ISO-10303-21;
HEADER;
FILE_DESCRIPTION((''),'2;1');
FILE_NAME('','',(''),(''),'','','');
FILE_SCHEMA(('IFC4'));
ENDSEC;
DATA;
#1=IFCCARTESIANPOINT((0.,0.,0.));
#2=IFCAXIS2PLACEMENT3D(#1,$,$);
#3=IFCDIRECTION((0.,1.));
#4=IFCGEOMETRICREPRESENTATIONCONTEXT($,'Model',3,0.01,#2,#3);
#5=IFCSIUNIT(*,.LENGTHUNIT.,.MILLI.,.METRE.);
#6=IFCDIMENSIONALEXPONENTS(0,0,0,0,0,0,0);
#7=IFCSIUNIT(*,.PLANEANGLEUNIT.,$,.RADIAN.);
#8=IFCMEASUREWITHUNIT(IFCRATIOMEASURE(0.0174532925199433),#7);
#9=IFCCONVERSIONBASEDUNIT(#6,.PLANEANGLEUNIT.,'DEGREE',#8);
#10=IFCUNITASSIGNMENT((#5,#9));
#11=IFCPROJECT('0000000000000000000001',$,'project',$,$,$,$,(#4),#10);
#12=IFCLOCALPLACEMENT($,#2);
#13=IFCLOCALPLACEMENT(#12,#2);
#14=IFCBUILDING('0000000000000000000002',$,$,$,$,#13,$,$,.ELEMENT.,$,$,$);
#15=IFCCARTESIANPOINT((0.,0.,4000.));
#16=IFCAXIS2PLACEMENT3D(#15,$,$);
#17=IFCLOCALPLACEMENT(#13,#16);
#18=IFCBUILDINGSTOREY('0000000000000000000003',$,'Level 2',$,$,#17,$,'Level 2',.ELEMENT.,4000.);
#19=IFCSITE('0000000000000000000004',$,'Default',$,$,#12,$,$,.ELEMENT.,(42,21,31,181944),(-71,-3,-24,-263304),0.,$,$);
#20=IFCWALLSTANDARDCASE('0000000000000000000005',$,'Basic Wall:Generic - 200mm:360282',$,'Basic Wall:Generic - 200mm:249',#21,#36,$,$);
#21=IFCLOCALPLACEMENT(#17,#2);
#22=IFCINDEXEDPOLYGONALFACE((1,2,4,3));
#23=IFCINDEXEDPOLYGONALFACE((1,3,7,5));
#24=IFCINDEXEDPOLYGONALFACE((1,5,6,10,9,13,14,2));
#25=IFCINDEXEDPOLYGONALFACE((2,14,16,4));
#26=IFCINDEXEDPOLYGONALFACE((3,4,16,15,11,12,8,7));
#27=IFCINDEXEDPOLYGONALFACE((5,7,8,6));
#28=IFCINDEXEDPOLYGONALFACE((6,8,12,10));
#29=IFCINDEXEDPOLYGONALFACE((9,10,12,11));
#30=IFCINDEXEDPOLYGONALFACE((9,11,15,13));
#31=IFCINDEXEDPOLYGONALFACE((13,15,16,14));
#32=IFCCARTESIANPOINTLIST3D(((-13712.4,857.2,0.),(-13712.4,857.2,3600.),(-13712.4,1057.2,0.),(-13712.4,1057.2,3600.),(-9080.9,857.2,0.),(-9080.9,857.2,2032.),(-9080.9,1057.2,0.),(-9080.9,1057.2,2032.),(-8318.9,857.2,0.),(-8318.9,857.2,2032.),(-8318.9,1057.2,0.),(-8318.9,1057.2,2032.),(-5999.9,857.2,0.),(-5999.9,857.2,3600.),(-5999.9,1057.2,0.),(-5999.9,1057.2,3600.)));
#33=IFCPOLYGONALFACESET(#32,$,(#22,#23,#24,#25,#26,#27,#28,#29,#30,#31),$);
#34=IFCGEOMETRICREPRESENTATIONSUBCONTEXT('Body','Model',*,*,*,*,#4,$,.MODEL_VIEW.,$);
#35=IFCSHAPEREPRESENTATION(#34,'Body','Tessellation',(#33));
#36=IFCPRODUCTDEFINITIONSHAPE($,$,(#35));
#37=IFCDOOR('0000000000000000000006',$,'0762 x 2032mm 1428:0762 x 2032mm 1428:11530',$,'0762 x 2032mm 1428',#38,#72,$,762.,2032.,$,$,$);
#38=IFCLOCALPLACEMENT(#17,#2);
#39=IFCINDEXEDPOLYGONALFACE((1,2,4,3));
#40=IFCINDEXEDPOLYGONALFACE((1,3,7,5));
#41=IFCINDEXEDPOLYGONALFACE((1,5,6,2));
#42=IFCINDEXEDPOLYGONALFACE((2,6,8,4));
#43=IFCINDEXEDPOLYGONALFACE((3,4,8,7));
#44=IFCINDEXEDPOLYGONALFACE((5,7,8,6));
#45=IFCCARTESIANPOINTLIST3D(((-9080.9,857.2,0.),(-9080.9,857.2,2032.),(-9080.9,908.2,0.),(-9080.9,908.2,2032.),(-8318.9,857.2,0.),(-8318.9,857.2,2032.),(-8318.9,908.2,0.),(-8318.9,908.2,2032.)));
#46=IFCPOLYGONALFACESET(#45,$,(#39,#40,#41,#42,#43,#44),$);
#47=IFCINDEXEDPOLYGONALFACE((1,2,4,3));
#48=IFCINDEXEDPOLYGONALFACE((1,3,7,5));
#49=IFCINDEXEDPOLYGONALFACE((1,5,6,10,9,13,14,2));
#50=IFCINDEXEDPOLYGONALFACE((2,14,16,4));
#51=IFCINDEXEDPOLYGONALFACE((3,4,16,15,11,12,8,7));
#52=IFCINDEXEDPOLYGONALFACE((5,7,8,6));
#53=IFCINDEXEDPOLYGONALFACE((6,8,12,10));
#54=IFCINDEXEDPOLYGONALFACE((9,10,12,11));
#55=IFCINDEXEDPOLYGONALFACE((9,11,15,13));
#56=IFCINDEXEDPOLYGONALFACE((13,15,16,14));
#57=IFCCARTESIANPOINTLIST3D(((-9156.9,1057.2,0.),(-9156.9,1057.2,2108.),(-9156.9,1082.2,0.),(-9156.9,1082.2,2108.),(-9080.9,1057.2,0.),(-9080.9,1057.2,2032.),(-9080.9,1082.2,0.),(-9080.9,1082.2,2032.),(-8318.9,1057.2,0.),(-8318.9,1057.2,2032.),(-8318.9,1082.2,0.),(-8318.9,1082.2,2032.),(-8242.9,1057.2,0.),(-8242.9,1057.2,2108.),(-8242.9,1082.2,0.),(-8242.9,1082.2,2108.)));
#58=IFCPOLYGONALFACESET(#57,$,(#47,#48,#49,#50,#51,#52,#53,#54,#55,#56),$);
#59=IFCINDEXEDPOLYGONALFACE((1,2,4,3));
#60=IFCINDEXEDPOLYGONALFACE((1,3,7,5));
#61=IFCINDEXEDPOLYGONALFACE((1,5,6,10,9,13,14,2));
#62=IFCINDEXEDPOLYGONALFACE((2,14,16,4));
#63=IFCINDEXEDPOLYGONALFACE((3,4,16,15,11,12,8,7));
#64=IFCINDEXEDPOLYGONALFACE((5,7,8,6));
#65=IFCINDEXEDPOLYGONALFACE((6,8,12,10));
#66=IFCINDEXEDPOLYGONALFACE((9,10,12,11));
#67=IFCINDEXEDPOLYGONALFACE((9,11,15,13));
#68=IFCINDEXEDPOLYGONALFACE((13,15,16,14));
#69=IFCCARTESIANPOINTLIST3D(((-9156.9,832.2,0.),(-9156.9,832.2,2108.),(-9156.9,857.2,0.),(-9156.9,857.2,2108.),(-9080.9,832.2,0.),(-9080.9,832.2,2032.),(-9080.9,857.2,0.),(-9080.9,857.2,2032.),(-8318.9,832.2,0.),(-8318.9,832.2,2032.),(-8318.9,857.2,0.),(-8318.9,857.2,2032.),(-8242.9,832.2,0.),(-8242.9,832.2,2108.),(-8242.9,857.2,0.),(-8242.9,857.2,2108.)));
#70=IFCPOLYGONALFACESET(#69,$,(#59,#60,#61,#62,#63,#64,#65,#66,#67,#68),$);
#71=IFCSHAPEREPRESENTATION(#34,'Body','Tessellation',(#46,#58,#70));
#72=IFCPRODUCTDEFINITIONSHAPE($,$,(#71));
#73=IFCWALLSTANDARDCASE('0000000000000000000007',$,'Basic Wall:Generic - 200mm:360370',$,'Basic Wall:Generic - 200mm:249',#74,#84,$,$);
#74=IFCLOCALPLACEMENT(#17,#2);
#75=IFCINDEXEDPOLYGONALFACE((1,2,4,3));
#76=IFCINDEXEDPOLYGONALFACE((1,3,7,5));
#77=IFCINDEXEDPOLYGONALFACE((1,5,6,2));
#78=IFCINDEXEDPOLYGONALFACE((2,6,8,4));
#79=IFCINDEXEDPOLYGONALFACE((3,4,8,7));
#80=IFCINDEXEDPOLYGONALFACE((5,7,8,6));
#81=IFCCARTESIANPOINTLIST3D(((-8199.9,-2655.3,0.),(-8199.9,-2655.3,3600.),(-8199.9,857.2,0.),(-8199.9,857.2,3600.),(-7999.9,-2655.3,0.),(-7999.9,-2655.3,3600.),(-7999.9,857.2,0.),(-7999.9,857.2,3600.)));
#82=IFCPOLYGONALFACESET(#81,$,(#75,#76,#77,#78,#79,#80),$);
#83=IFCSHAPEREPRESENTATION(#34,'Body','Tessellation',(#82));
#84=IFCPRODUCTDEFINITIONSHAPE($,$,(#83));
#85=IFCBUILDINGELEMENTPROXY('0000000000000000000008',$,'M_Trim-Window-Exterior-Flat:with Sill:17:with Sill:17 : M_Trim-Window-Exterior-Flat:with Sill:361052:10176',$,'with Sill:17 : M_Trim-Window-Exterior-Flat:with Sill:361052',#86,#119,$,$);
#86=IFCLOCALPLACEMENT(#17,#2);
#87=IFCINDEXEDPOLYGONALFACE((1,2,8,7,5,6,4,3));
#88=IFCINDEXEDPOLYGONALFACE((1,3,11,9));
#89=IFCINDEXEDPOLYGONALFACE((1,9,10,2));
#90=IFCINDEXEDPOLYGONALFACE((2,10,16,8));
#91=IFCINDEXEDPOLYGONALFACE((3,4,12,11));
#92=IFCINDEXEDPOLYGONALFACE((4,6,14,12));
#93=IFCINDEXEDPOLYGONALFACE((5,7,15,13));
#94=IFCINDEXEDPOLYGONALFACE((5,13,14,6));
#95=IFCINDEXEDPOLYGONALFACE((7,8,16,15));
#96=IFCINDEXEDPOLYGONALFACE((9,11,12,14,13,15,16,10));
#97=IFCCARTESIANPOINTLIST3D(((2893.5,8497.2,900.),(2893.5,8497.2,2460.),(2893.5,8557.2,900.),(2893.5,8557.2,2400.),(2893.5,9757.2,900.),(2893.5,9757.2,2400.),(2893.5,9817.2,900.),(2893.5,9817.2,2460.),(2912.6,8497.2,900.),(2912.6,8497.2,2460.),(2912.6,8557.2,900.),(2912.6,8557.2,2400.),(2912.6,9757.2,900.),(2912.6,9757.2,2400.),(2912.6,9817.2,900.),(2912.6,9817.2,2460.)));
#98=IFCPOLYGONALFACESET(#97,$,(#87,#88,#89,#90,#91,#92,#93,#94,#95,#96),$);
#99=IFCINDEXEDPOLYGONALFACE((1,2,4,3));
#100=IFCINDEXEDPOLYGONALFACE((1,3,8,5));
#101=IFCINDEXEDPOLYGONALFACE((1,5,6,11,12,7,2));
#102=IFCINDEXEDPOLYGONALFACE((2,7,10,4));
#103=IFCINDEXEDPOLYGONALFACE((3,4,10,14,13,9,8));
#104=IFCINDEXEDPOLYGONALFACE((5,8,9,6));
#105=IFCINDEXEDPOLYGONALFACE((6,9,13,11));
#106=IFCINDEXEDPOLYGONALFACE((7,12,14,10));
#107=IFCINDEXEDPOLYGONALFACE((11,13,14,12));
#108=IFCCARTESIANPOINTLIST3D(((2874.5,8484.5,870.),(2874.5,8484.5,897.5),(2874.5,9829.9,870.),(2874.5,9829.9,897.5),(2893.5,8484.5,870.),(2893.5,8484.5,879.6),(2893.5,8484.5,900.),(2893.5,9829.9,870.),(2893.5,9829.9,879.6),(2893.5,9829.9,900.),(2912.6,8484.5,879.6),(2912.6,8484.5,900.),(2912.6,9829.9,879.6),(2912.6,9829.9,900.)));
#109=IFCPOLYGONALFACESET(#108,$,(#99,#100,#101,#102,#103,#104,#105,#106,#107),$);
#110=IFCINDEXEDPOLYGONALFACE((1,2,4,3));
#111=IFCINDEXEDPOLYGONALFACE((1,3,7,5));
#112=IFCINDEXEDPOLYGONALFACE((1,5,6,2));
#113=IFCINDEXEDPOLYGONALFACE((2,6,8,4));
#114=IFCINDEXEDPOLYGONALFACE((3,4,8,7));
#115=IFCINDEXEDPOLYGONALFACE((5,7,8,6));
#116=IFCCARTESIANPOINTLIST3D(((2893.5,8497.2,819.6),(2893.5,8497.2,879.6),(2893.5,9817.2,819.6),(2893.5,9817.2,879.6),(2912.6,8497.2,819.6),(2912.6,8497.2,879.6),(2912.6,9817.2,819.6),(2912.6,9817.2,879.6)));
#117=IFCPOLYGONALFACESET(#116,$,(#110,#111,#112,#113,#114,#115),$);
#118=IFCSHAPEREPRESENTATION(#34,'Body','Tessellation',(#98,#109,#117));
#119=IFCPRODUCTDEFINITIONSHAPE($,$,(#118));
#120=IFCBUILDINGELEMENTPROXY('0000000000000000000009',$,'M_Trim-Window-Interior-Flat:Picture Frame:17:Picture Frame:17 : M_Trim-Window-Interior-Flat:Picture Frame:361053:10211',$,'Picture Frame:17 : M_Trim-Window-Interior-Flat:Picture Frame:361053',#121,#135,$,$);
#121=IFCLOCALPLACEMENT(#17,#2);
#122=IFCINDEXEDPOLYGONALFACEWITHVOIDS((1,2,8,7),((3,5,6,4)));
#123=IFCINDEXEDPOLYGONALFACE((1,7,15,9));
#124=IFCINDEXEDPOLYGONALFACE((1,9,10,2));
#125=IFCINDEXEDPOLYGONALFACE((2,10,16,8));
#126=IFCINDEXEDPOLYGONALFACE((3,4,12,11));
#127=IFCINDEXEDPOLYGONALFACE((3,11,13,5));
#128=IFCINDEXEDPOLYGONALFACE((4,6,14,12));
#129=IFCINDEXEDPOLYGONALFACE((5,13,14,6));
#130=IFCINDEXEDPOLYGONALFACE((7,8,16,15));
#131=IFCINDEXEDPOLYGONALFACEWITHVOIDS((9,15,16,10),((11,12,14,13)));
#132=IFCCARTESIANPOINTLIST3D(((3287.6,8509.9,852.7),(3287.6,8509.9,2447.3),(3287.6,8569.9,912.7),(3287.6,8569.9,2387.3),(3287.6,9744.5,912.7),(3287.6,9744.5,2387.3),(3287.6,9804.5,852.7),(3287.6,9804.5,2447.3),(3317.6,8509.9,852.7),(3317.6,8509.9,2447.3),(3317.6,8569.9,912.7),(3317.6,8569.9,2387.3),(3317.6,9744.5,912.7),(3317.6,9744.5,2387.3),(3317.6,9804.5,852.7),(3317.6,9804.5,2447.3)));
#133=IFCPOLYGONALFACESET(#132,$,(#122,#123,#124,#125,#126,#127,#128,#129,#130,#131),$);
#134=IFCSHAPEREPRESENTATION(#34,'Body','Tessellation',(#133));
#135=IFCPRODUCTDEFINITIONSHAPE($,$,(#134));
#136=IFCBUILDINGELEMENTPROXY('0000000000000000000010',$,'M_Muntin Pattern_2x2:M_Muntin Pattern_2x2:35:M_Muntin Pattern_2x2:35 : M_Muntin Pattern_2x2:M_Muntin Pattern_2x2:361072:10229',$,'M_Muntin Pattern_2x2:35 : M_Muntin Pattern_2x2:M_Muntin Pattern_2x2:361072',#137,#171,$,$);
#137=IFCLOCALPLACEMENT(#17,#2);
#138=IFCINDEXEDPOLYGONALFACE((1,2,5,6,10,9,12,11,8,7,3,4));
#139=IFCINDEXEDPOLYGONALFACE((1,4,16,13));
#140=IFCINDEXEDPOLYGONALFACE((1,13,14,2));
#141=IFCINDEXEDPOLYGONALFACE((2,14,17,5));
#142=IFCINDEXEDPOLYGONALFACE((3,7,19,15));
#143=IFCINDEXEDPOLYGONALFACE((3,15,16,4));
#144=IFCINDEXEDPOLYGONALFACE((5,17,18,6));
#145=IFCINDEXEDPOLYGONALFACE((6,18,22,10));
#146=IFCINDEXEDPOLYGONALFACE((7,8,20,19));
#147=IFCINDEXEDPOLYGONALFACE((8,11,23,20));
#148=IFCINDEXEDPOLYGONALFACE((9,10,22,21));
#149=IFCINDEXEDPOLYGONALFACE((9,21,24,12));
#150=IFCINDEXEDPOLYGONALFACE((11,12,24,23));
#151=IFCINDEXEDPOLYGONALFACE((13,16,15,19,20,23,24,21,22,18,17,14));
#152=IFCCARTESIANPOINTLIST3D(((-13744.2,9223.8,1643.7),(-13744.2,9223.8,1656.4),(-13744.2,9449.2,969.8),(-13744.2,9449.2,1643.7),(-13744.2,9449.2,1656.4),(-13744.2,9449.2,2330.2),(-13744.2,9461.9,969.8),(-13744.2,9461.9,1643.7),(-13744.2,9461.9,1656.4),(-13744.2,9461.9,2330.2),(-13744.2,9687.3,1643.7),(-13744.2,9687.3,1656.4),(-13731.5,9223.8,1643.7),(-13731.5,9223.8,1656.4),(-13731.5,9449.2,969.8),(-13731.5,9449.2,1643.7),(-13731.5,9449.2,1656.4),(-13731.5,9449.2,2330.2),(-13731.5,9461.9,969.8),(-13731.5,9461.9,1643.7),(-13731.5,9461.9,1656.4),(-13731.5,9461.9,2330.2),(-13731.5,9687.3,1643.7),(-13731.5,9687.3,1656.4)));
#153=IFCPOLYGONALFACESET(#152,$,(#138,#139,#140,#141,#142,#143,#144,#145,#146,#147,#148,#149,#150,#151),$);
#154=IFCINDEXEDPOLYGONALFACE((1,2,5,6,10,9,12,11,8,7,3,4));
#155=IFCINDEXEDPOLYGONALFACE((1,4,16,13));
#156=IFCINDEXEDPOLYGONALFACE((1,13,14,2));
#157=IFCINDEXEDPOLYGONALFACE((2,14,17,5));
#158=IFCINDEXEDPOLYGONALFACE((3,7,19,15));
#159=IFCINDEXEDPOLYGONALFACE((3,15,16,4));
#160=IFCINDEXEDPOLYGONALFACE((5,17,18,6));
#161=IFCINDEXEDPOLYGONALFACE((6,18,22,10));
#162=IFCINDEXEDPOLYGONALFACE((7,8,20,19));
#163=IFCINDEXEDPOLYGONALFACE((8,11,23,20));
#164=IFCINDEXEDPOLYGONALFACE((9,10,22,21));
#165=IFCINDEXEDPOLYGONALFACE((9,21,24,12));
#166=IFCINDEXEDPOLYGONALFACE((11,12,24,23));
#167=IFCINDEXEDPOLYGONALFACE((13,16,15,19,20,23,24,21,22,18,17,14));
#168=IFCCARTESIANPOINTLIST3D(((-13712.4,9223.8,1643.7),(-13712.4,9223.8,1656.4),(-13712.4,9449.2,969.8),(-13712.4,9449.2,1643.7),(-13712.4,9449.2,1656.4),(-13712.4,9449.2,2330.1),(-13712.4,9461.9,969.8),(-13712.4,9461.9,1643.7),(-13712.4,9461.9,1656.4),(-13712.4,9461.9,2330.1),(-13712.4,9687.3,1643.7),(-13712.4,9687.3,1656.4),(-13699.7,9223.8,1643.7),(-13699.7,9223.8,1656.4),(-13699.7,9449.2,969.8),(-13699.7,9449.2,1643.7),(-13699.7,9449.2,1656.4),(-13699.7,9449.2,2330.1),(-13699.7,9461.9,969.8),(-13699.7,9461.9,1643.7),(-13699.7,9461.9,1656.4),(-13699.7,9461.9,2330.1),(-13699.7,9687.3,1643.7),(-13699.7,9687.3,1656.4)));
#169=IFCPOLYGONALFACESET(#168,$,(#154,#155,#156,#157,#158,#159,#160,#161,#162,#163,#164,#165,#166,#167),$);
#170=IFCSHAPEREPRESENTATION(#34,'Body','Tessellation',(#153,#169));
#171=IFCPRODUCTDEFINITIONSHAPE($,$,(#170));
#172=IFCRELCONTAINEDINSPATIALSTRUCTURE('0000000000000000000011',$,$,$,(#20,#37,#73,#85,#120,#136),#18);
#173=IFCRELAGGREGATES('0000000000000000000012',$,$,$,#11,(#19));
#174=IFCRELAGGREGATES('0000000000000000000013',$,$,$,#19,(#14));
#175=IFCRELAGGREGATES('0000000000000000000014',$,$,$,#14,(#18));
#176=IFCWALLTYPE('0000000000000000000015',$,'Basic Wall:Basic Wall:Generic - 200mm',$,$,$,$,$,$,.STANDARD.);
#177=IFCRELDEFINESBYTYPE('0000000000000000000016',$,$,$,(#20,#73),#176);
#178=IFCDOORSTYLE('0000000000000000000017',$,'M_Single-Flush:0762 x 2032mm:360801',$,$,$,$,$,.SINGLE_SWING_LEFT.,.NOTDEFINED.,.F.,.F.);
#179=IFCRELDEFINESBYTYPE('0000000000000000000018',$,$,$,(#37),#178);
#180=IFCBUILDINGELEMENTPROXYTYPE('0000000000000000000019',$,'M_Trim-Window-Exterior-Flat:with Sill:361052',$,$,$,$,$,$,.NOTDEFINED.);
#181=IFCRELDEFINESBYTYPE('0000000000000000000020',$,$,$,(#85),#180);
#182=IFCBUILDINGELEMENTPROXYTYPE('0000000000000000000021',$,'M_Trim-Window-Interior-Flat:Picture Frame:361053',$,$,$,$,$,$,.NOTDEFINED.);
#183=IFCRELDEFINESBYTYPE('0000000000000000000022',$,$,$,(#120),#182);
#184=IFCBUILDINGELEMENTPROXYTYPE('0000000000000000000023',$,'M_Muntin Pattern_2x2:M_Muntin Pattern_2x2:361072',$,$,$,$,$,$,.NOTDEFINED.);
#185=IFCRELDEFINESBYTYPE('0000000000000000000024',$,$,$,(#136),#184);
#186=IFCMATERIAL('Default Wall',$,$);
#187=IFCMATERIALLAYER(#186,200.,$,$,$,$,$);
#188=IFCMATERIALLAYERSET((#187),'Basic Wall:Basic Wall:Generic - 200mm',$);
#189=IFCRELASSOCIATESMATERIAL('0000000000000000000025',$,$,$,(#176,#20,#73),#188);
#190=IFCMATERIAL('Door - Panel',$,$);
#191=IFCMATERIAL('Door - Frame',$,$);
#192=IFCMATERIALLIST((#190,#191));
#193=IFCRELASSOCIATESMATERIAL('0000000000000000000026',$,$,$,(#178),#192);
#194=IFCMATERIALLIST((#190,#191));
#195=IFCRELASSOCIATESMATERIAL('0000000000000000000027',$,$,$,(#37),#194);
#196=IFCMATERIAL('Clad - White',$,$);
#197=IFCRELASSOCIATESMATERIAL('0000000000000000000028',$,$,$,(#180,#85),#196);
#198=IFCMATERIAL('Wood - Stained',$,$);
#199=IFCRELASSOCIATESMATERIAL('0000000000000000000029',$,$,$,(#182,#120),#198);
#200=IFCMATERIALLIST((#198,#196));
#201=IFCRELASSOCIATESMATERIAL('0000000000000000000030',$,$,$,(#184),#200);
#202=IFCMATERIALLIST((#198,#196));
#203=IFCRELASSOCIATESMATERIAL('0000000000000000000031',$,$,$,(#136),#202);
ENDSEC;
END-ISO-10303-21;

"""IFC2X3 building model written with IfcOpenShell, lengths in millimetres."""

from ifc_helpers import new_model, entity, si_unit, converted_unit, direction, frame, frame_2d, origin, origin_2d_with_axis, place, context, subcontext, project, spatial, polyline, rectangle, outline, extrude, source, transform, mapped, material, material_list, layer, layer_set, layer_usage, type_object, type_shapes, element, fill, save


model = new_model("IFC2X3")

# Units and contexts
model_context = context("Model", 3, precision=0.01, world=origin(), true_north=direction((0.0, 1.0)))
body_context = subcontext(model_context, "Body", "Model", "MODEL_VIEW")
ifc_project = project(units=[si_unit("LENGTHUNIT", "METRE", prefix="MILLI"), converted_unit("PLANEANGLEUNIT", "DEGREE", entity("IfcRatioMeasure", 0.0174532925199433), si_unit("PLANEANGLEUNIT", "RADIAN"), dimensions=[0, 0, 0, 0, 0, 0, 0])], contexts=[model_context])

# Site, building, storey
site_placement = place(None, origin())
site = spatial("IfcSite", under=ifc_project, at=site_placement, Name="Default", CompositionType="ELEMENT", RefLatitude=(42, 21, 31, 181944), RefLongitude=(-71, -3, -24, -263304), RefElevation=0.0)
building_placement = place(site_placement, origin())
building = spatial("IfcBuilding", under=site, at=building_placement, CompositionType="ELEMENT")
storey_placement = place(building_placement, frame((0.0, 0.0, 4000.0)))
storey = spatial("IfcBuildingStorey", under=building, at=storey_placement, Name="Level 2", LongName="Level 2", CompositionType="ELEMENT", Elevation=4000.0)

# Shared definitions
ifc_material_1 = material(Name="Default Wall")
ifc_material_2 = material(Name="Door - Panel")
ifc_material_3 = material(Name="Door - Frame")

# Shared definitions
ifc_layer_1 = layer(ifc_material_1, 200.0)
ifc_layer_set_1 = layer_set([ifc_layer_1], Name="Basic Wall:Basic Wall:Generic - 200mm")
wall_type_1 = type_object("IfcWallType", Name="Basic Wall:Basic Wall:Generic - 200mm", PredefinedType="STANDARD", material=ifc_layer_set_1)
ifc_material_list_1 = material_list([ifc_material_2, ifc_material_3])
door_style_1 = type_object("IfcDoorStyle", Name="M_Single-Flush:0762 x 2032mm:360801", ConstructionType="NOTDEFINED", OperationType="SINGLE_SWING_LEFT", ParameterTakesPrecedence=False, Sizeable=False, material=ifc_material_list_1)
shared_shape_1 = source(origin(), body_context, "Body", "SweptSolid", [
    extrude(rectangle(XDim=51.0, YDim=762.0, at=origin_2d_with_axis()), frame((381.0, -27.5, 0.0), z_axis=(0.0, 0.0, 1.0), x_axis=(0.0, 1.0, 0.0)), (0.0, 0.0, 1.0), 2032.0),
    extrude(outline(polyline([(-1035.0, -457.0), (1073.0, -457.0), (1073.0, 457.0), (-1035.0, 457.0), (-1035.0, 381.0), (997.0, 381.0), (997.0, -381.0), (-1035.0, -381.0), (-1035.0, -457.0)])), frame((381.0, -227.0, 1035.0), z_axis=(0.0, 1.0, 0.0), x_axis=(0.0, 0.0, 1.0)), (0.0, 0.0, 1.0), 25.0),
    extrude(outline(polyline([(-457.0, -1073.0), (457.0, -1073.0), (457.0, 1035.0), (381.0, 1035.0), (381.0, -997.0), (-381.0, -997.0), (-381.0, 1035.0), (-457.0, 1035.0), (-457.0, -1073.0)])), frame((381.0, -2.0, 1035.0), z_axis=(0.0, 1.0, 0.0), x_axis=(1.0, 0.0, 0.0)), (0.0, 0.0, 1.0), 25.0),
])
type_shapes(door_style_1, [shared_shape_1])

# Wall, opening, door
ifc_layer_usage_1 = layer_usage(ifc_layer_set_1, "AXIS2", "NEGATIVE", 100.0)
wall_1_placement = place(storey_placement, frame((-5999.9, 957.2, 0.0), z_axis=(0.0, 0.0, 1.0), x_axis=(-1.0, 0.0, 0.0)))
wall_1 = element("IfcWallStandardCase", 1, at=wall_1_placement, inside=storey, type_object=wall_type_1, material=ifc_layer_usage_1, Name="Basic Wall:Generic - 200mm:360282", ObjectType="Basic Wall:Generic - 200mm:249", context=body_context, shape_type="SweptSolid", body=[
    extrude(rectangle(XDim=7712.5, YDim=200.0, at=frame_2d((3856.2, 0.0), x_axis=(-1.0, 0.0))), origin(), (0.0, 0.0, 1.0), 3600.0),
])
opening_1_placement = place(wall_1_placement, frame((-5999.9, 957.2, 0.0), z_axis=(0.0, 0.0, 1.0), x_axis=(-1.0, 0.0, 0.0)))
opening_1 = element("IfcOpeningElement", 2, at=opening_1_placement, cuts=wall_1, ObjectType="Opening", context=body_context, shape_type="SweptSolid", body=[
    extrude(rectangle(XDim=2032.0, YDim=762.0, at=frame_2d((0.0, 0.0), x_axis=(1.0, 0.0))), frame((-8699.9, 1059.2, 1016.0), z_axis=(0.0, -1.0, 0.0), x_axis=(0.0, 0.0, 1.0)), (0.0, 0.0, 1.0), 204.0),
])
ifc_material_list_2 = material_list([ifc_material_2, ifc_material_3])
door_1_placement = place(opening_1_placement, frame((-8318.9, 855.2, 0.0), z_axis=(0.0, 0.0, 1.0), x_axis=(-1.0, 0.0, 0.0)))
door_1 = element("IfcDoor", 3, at=door_1_placement, inside=storey, type_object=door_style_1, material=ifc_material_list_2, Name="0762 x 2032mm 1428:0762 x 2032mm 1428:11530", ObjectType="0762 x 2032mm 1428", OverallHeight=762.0, OverallWidth=2032.0, context=body_context, shape_type="MappedRepresentation", body=[
    mapped(shared_shape_1, transform((0.0, 0.0, 0.0), scale=1.0)),
])
fill(opening_1, door_1)

# Wall
ifc_layer_usage_2 = layer_usage(ifc_layer_set_1, "AXIS2", "NEGATIVE", 100.0)
wall_2_placement = place(storey_placement, frame((-8099.9, 857.2, 0.0), z_axis=(0.0, 0.0, 1.0), x_axis=(0.0, -1.0, 0.0)))
element("IfcWallStandardCase", 4, at=wall_2_placement, inside=storey, type_object=wall_type_1, material=ifc_layer_usage_2, Name="Basic Wall:Generic - 200mm:360370", ObjectType="Basic Wall:Generic - 200mm:249", context=body_context, shape_type="SweptSolid", body=[
    extrude(rectangle(XDim=3512.5, YDim=200.0, at=frame_2d((1756.2, 0.0), x_axis=(-1.0, 0.0))), origin(), (0.0, 0.0, 1.0), 3600.0),
])

# Building element proxies
ifc_material_4 = material(Name="Clad - White")
building_element_proxy_type_1 = type_object("IfcBuildingElementProxyType", Name="M_Trim-Window-Exterior-Flat:with Sill:361052", PredefinedType="NOTDEFINED", material=ifc_material_4)
shared_shape_2 = source(origin(), body_context, "Body", "SweptSolid", [
    extrude(outline(polyline([(-765.0, -660.0), (795.0, -660.0), (795.0, 660.0), (-765.0, 660.0), (-765.0, 600.0), (735.0, 600.0), (735.0, -600.0), (-765.0, -600.0), (-765.0, -660.0)])), frame((2893.5, 9157.2, 5665.0), z_axis=(1.0, 0.0, 0.0), x_axis=(0.0, 0.0, 1.0)), (0.0, 0.0, 1.0), 19.1),
    extrude(outline(polyline([(0.0, -15.2), (19.0, -15.2), (19.0, 12.3), (0.0, 14.8), (-19.0, 14.8), (-19.0, -5.7), (0.0, -5.7), (0.0, -15.2)])), frame((2893.5, 8484.5, 4885.2), z_axis=(0.0, 1.0, 0.0), x_axis=(-1.0, 0.0, 0.0)), (0.0, 0.0, 1.0), 1345.4),
    extrude(rectangle(XDim=19.1, YDim=1320.0, at=frame_2d((0.0, 0.0), x_axis=(1.0, 0.0))), frame((2903.0, 9157.2, 4819.6)), (0.0, 0.0, 1.0), 60.0),
])
type_shapes(building_element_proxy_type_1, [shared_shape_2])
proxy_1_placement = place(storey_placement, frame((0.0, 0.0, -4000.0)))
element("IfcBuildingElementProxy", 5, at=proxy_1_placement, inside=storey, type_object=building_element_proxy_type_1, material=ifc_material_4, Name="M_Trim-Window-Exterior-Flat:with Sill:17:with Sill:17 : M_Trim-Window-Exterior-Flat:with Sill:361052:10176", ObjectType="with Sill:17 : M_Trim-Window-Exterior-Flat:with Sill:361052", context=body_context, shape_type="MappedRepresentation", body=[
    mapped(shared_shape_2, transform((0.0, 0.0, 0.0), scale=1.0)),
])
ifc_material_5 = material(Name="Wood - Stained")
building_element_proxy_type_2 = type_object("IfcBuildingElementProxyType", Name="M_Trim-Window-Interior-Flat:Picture Frame:361053", PredefinedType="NOTDEFINED", material=ifc_material_5)
shared_shape_3 = source(origin(), body_context, "Body", "SweptSolid", [
    extrude(outline(polyline([(-797.3, -647.3), (797.3, -647.3), (797.3, 647.3), (-797.3, 647.3), (-797.3, -647.3)]), holes=[polyline([(737.3, 587.3), (737.3, -587.3), (-737.3, -587.3), (-737.3, 587.3), (737.3, 587.3)])]), frame((3287.6, 9157.2, 5650.0), z_axis=(1.0, 0.0, 0.0), x_axis=(0.0, 0.0, -1.0)), (0.0, 0.0, 1.0), 30.0),
])
type_shapes(building_element_proxy_type_2, [shared_shape_3])
proxy_2_placement = place(storey_placement, frame((0.0, 0.0, -4000.0)))
element("IfcBuildingElementProxy", 6, at=proxy_2_placement, inside=storey, type_object=building_element_proxy_type_2, material=ifc_material_5, Name="M_Trim-Window-Interior-Flat:Picture Frame:17:Picture Frame:17 : M_Trim-Window-Interior-Flat:Picture Frame:361053:10211", ObjectType="Picture Frame:17 : M_Trim-Window-Interior-Flat:Picture Frame:361053", context=body_context, shape_type="MappedRepresentation", body=[
    mapped(shared_shape_3, transform((0.0, 0.0, 0.0), scale=1.0)),
])
ifc_material_list_3 = material_list([ifc_material_5, ifc_material_4])
ifc_material_list_4 = material_list([ifc_material_5, ifc_material_4])
building_element_proxy_type_3 = type_object("IfcBuildingElementProxyType", Name="M_Muntin Pattern_2x2:M_Muntin Pattern_2x2:361072", PredefinedType="NOTDEFINED", material=ifc_material_list_4)
shared_shape_4 = source(origin(), body_context, "Body", "SweptSolid", [
    extrude(outline(polyline([(-6.4, -680.2), (6.3, -680.2), (6.3, -6.4), (231.7, -6.4), (231.7, 6.3), (6.3, 6.3), (6.3, 680.2), (-6.4, 680.2), (-6.4, 6.3), (-231.7, 6.3), (-231.7, -6.4), (-6.4, -6.4), (-6.4, -680.2)])), frame((-13744.2, 9455.6, 5650.0), z_axis=(1.0, 0.0, 0.0), x_axis=(0.0, -1.0, 0.0)), (0.0, 0.0, 1.0), 12.7),
    extrude(outline(polyline([(-6.4, -680.1), (6.3, -680.1), (6.3, -6.4), (231.7, -6.4), (231.7, 6.3), (6.3, 6.3), (6.3, 680.2), (-6.4, 680.2), (-6.4, 6.3), (-231.7, 6.3), (-231.7, -6.4), (-6.4, -6.4), (-6.4, -680.1)])), frame((-13712.4, 9455.6, 5650.0), z_axis=(1.0, 0.0, 0.0), x_axis=(0.0, -1.0, 0.0)), (0.0, 0.0, 1.0), 12.7),
])
type_shapes(building_element_proxy_type_3, [shared_shape_4])
proxy_3_placement = place(storey_placement, frame((0.0, 0.0, -4000.0)))
element("IfcBuildingElementProxy", 7, at=proxy_3_placement, inside=storey, type_object=building_element_proxy_type_3, material=ifc_material_list_3, Name="M_Muntin Pattern_2x2:M_Muntin Pattern_2x2:35:M_Muntin Pattern_2x2:35 : M_Muntin Pattern_2x2:M_Muntin Pattern_2x2:361072:10229", ObjectType="M_Muntin Pattern_2x2:35 : M_Muntin Pattern_2x2:M_Muntin Pattern_2x2:361072", context=body_context, shape_type="MappedRepresentation", body=[
    mapped(shared_shape_4, transform((0.0, 0.0, 0.0), scale=1.0)),
])

save(model, "model.ifc")
